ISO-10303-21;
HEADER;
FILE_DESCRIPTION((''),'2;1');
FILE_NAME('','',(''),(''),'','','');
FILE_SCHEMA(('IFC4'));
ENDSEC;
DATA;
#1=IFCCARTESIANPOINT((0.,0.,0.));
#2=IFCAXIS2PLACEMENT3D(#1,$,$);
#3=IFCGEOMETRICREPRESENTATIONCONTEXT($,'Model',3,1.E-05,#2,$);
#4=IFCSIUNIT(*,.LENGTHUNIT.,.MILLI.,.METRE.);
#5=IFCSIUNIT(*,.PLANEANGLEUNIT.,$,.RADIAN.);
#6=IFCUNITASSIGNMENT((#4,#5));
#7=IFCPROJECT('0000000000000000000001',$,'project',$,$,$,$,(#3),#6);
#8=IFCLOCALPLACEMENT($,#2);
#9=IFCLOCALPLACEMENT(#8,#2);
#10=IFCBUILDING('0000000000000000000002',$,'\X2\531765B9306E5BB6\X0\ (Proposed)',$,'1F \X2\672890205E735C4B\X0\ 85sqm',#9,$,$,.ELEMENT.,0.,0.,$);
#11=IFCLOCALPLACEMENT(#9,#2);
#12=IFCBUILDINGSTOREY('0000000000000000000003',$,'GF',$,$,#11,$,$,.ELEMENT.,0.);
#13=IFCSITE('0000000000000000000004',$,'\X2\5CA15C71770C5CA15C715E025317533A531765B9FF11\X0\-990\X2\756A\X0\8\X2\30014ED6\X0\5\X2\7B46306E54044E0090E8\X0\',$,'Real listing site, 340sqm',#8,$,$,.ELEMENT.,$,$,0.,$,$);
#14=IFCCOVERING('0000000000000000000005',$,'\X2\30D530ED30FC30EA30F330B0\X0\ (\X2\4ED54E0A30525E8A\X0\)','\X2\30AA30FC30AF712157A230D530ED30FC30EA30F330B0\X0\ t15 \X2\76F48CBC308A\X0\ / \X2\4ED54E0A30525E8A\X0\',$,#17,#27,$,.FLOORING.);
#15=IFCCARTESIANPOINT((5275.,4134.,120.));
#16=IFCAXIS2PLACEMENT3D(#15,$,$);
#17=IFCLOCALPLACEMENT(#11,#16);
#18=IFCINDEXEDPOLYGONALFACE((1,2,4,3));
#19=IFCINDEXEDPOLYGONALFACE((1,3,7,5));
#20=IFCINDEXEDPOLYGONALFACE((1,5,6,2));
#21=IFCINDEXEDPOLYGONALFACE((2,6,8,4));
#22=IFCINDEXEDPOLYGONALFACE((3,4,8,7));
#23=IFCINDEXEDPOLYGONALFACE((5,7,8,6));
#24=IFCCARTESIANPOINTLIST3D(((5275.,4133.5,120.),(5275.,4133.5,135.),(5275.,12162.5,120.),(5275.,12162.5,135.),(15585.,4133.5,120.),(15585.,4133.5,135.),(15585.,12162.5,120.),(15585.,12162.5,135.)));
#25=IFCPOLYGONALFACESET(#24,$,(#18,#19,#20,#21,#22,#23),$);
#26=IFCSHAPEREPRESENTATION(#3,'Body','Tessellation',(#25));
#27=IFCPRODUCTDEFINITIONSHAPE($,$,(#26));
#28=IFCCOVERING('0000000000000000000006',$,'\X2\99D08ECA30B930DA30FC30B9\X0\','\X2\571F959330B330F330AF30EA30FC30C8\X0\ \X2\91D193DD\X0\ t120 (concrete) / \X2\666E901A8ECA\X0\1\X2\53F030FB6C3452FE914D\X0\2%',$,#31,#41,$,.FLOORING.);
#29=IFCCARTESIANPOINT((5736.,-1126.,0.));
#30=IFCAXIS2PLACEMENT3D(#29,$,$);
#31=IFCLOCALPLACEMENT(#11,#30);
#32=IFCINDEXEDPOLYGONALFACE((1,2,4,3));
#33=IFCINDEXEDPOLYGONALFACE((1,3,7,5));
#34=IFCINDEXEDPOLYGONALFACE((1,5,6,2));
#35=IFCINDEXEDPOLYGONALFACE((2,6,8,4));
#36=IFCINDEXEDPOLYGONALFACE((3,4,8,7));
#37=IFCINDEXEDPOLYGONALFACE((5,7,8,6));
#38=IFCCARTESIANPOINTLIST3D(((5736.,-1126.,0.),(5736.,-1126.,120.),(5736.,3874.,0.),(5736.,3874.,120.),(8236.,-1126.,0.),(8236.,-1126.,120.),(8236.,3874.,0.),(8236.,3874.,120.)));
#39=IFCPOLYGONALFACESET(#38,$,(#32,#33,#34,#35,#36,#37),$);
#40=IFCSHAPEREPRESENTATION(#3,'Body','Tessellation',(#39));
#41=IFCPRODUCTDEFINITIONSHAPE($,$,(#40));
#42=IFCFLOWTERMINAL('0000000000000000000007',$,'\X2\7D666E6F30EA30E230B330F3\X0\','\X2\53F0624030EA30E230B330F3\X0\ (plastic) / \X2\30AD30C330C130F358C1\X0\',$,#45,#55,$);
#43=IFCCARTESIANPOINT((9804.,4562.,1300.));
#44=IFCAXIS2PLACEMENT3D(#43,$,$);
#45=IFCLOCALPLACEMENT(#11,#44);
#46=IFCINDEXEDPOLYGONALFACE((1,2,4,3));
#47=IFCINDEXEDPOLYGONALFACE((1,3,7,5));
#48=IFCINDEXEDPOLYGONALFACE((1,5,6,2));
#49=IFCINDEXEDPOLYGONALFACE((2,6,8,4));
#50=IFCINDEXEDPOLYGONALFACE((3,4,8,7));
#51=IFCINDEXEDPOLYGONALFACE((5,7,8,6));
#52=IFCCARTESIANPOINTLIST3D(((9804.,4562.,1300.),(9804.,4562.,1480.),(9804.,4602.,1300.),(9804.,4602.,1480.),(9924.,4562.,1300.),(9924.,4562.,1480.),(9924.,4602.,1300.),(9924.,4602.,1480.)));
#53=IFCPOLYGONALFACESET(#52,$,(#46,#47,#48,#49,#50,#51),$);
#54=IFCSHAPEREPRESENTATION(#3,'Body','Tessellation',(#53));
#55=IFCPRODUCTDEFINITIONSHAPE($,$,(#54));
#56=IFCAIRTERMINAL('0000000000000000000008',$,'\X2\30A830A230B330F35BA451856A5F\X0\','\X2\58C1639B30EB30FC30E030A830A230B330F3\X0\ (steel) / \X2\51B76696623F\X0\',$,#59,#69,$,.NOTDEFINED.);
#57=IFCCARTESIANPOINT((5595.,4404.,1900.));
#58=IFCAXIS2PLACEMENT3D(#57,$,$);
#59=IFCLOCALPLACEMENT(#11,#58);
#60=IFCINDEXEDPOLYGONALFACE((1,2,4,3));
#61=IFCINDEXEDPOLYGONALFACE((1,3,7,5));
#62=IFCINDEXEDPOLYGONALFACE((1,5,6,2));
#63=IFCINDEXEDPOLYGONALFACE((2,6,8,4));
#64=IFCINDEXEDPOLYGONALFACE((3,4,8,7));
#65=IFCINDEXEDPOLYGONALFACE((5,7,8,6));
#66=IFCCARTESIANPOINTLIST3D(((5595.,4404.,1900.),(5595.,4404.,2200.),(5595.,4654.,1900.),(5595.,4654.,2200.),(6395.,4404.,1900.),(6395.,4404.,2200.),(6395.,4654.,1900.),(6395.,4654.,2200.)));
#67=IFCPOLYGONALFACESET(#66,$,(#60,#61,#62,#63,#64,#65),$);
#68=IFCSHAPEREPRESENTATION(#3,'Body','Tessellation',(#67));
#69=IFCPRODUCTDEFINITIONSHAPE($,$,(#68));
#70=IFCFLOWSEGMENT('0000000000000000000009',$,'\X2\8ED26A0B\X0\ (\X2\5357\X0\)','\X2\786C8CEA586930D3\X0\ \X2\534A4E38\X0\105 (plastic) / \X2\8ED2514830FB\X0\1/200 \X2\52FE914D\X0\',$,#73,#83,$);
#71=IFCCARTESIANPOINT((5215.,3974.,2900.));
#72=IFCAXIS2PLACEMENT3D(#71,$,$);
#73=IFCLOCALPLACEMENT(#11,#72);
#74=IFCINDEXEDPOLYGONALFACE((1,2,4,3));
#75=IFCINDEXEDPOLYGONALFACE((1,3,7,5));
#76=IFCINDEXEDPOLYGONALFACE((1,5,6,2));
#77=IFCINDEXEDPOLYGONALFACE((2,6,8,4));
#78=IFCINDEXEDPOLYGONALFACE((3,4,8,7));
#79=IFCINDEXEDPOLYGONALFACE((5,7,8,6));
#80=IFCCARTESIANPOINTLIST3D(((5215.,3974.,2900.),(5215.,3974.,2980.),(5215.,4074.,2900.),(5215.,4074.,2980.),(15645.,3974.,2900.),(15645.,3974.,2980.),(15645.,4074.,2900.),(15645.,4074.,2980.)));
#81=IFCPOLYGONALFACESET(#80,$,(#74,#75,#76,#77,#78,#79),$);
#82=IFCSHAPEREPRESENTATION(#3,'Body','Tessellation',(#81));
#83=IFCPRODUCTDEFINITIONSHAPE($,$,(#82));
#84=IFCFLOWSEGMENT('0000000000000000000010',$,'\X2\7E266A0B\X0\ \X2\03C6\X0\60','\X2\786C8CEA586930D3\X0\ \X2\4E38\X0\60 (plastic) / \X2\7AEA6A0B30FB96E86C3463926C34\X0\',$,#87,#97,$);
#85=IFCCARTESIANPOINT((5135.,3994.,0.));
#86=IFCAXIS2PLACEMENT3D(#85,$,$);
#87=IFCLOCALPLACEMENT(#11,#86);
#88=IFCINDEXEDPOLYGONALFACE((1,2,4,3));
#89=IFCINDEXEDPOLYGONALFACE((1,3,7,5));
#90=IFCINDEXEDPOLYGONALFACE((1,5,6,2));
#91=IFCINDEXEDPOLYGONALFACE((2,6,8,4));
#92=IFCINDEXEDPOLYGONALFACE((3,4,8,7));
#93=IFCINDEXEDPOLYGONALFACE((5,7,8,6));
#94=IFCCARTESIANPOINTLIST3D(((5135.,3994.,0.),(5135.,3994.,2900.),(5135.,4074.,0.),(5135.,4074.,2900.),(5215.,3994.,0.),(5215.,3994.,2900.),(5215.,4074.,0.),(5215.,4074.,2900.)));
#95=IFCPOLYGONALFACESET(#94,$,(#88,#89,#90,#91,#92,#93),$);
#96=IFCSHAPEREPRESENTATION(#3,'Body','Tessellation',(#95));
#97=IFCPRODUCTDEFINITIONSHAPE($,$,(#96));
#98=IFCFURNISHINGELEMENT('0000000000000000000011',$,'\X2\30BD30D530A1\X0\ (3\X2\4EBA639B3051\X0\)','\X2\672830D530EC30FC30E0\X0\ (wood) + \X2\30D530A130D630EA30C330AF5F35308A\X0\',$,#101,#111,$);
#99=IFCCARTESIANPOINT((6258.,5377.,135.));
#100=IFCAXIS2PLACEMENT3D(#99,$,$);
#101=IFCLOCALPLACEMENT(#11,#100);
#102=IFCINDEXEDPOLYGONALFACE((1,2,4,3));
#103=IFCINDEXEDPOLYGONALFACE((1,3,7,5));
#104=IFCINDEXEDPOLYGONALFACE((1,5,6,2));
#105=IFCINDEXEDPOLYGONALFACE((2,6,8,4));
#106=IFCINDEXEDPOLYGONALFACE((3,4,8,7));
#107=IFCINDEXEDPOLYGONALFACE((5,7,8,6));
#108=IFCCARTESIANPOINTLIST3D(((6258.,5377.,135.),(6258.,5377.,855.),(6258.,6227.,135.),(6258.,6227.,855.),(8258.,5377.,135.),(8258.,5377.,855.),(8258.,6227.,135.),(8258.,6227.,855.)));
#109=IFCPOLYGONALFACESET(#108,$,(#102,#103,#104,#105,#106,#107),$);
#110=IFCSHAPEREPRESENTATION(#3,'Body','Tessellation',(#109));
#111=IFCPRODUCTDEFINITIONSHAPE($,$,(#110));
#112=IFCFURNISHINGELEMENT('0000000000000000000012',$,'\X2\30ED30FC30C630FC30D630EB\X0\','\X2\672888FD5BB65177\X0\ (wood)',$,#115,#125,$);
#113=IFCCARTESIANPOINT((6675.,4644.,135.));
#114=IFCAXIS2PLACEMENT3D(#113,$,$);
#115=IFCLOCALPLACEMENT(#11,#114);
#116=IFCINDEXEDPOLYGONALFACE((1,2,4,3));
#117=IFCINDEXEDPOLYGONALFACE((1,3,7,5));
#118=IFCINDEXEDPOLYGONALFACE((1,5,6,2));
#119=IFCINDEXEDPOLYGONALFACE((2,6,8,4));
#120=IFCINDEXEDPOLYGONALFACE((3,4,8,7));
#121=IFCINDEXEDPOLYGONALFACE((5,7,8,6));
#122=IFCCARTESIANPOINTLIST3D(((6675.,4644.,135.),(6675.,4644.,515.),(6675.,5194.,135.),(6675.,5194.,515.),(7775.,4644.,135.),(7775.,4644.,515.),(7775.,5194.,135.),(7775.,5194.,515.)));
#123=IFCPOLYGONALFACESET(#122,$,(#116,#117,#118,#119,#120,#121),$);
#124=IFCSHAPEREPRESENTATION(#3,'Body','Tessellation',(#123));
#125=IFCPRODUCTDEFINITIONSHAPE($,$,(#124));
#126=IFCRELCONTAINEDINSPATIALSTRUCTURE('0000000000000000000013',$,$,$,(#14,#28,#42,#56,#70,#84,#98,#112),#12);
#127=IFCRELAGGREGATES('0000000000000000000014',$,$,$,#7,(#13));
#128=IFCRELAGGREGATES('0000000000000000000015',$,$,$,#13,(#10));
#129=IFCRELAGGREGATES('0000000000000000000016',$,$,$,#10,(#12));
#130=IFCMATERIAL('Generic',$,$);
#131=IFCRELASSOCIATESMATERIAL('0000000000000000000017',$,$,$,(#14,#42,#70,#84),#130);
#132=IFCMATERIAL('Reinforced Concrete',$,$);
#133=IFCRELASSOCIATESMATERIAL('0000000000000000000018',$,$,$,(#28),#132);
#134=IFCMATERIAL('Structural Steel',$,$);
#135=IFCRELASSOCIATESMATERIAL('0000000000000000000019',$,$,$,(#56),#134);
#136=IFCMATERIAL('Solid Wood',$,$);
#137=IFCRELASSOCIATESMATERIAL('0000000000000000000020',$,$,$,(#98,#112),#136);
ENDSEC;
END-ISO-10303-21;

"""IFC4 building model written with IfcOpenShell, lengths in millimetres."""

from ifc_helpers import new_model, si_unit, frame, frame_2d, origin, place, context, project, spatial, rectangle, extrude, material, element, save


model = new_model("IFC4")

# Units and contexts
model_context = context("Model", 3, precision=1e-05, world=origin())
ifc_project = project(units=[si_unit("LENGTHUNIT", "METRE", prefix="MILLI"), si_unit("PLANEANGLEUNIT", "RADIAN")], contexts=[model_context])

# Site, building, storey
site_placement = place(None, origin())
site = spatial("IfcSite", under=ifc_project, at=site_placement, Name="岡山県岡山市北区北方１-990番8、他5筆の各一部", ObjectType="Real listing site, 340sqm", CompositionType="ELEMENT", RefElevation=0.0)
building_placement = place(site_placement, origin())
building = spatial("IfcBuilding", under=site, at=building_placement, Name="北方の家 (Proposed)", ObjectType="1F 木造平屋 85sqm", CompositionType="ELEMENT", ElevationOfRefHeight=0.0, ElevationOfTerrain=0.0)
storey_placement = place(building_placement, origin())
storey = spatial("IfcBuildingStorey", under=building, at=storey_placement, Name="GF", CompositionType="ELEMENT", Elevation=0.0)

# Shared definitions
ifc_material_1 = material(Name="Solid Wood")

# Shared definitions
ifc_material_2 = material(Name="Reinforced Concrete")

# Shared definitions
ifc_material_3 = material(Name="Structural Steel")

# Coverings
ifc_material_4 = material(Name="Generic")
covering_1_placement = place(storey_placement, frame((5275.0, 4134.0, 120.0)))
element("IfcCovering", 1, at=covering_1_placement, inside=storey, material=ifc_material_4, Name="フローリング (仕上げ床)", Description="オーク無垢フローリング t15 直貼り / 仕上げ床", PredefinedType="FLOORING", context=model_context, shape_type="SweptSolid", body=[
    extrude(rectangle(XDim=10310.0, YDim=8029.0, at=frame_2d((5155.0, 4014.0))), frame((5275.0, 4134.0, 120.0)), (0.0, 0.0, 1.0), 15.0),
])
covering_2_placement = place(storey_placement, frame((5736.0, -1126.0, 0.0)))
element("IfcCovering", 2, at=covering_2_placement, inside=storey, material=ifc_material_2, Name="駐車スペース", Description="土間コンクリート 金鏝 t120 (concrete) / 普通車1台・水勾配2%", PredefinedType="FLOORING", context=model_context, shape_type="SweptSolid", body=[
    extrude(rectangle(XDim=2500.0, YDim=5000.0, at=frame_2d((1250.0, 2500.0))), frame((5736.0, -1126.0, 0.0)), (0.0, 0.0, 1.0), 120.0),
])

# Flow terminal
flow_terminal_placement = place(storey_placement, frame((9804.0, 4562.0, 1300.0)))
element("IfcFlowTerminal", 3, at=flow_terminal_placement, inside=storey, material=ifc_material_4, Name="給湯リモコン", Description="台所リモコン (plastic) / キッチン壁", context=model_context, shape_type="SweptSolid", body=[
    extrude(rectangle(XDim=120.0, YDim=40.0, at=frame_2d((60.0, 20.0))), frame((9804.0, 4562.0, 1300.0)), (0.0, 0.0, 1.0), 180.0),
])

# Air terminal
air_terminal_placement = place(storey_placement, frame((5595.0, 4404.0, 1900.0)))
element("IfcAirTerminal", 4, at=air_terminal_placement, inside=storey, material=ifc_material_3, Name="エアコン室内機", Description="壁掛ルームエアコン (steel) / 冷暖房", PredefinedType="NOTDEFINED", context=model_context, shape_type="SweptSolid", body=[
    extrude(rectangle(XDim=800.0, YDim=250.0, at=frame_2d((400.0, 125.0))), frame((5595.0, 4404.0, 1900.0)), (0.0, 0.0, 1.0), 300.0),
])

# Flow segments
flow_segment_1_placement = place(storey_placement, frame((5215.0, 3974.0, 2900.0)))
element("IfcFlowSegment", 5, at=flow_segment_1_placement, inside=storey, material=ifc_material_4, Name="軒樋 (南)", Description="硬質塩ビ 半丸105 (plastic) / 軒先・1/200 勾配", context=model_context, shape_type="SweptSolid", body=[
    extrude(rectangle(XDim=10430.0, YDim=100.0, at=frame_2d((5215.0, 50.0))), frame((5215.0, 3974.0, 2900.0)), (0.0, 0.0, 1.0), 80.0),
])
flow_segment_2_placement = place(storey_placement, frame((5135.0, 3994.0, 0.0)))
element("IfcFlowSegment", 6, at=flow_segment_2_placement, inside=storey, material=ifc_material_4, Name="縦樋 φ60", Description="硬質塩ビ 丸60 (plastic) / 竪樋・雨水排水", context=model_context, shape_type="SweptSolid", body=[
    extrude(rectangle(XDim=80.0, YDim=80.0, at=frame_2d((40.0, 40.0))), frame((5135.0, 3994.0, 0.0)), (0.0, 0.0, 1.0), 2900.0),
])

# Furnishing elements
furnishing_1_placement = place(storey_placement, frame((6258.0, 5377.0, 135.0)))
element("IfcFurnishingElement", 7, at=furnishing_1_placement, inside=storey, material=ifc_material_1, Name="ソファ (3人掛け)", Description="木フレーム (wood) + ファブリック張り", context=model_context, shape_type="SweptSolid", body=[
    extrude(rectangle(XDim=2000.0, YDim=850.0, at=frame_2d((1000.0, 425.0))), frame((6258.0, 5377.0, 135.0)), (0.0, 0.0, 1.0), 720.0),
])
furnishing_2_placement = place(storey_placement, frame((6675.0, 4644.0, 135.0)))
element("IfcFurnishingElement", 8, at=furnishing_2_placement, inside=storey, material=ifc_material_1, Name="ローテーブル", Description="木製家具 (wood)", context=model_context, shape_type="SweptSolid", body=[
    extrude(rectangle(XDim=1100.0, YDim=550.0, at=frame_2d((550.0, 275.0))), frame((6675.0, 4644.0, 135.0)), (0.0, 0.0, 1.0), 380.0),
])

save(model, "model.ifc")
